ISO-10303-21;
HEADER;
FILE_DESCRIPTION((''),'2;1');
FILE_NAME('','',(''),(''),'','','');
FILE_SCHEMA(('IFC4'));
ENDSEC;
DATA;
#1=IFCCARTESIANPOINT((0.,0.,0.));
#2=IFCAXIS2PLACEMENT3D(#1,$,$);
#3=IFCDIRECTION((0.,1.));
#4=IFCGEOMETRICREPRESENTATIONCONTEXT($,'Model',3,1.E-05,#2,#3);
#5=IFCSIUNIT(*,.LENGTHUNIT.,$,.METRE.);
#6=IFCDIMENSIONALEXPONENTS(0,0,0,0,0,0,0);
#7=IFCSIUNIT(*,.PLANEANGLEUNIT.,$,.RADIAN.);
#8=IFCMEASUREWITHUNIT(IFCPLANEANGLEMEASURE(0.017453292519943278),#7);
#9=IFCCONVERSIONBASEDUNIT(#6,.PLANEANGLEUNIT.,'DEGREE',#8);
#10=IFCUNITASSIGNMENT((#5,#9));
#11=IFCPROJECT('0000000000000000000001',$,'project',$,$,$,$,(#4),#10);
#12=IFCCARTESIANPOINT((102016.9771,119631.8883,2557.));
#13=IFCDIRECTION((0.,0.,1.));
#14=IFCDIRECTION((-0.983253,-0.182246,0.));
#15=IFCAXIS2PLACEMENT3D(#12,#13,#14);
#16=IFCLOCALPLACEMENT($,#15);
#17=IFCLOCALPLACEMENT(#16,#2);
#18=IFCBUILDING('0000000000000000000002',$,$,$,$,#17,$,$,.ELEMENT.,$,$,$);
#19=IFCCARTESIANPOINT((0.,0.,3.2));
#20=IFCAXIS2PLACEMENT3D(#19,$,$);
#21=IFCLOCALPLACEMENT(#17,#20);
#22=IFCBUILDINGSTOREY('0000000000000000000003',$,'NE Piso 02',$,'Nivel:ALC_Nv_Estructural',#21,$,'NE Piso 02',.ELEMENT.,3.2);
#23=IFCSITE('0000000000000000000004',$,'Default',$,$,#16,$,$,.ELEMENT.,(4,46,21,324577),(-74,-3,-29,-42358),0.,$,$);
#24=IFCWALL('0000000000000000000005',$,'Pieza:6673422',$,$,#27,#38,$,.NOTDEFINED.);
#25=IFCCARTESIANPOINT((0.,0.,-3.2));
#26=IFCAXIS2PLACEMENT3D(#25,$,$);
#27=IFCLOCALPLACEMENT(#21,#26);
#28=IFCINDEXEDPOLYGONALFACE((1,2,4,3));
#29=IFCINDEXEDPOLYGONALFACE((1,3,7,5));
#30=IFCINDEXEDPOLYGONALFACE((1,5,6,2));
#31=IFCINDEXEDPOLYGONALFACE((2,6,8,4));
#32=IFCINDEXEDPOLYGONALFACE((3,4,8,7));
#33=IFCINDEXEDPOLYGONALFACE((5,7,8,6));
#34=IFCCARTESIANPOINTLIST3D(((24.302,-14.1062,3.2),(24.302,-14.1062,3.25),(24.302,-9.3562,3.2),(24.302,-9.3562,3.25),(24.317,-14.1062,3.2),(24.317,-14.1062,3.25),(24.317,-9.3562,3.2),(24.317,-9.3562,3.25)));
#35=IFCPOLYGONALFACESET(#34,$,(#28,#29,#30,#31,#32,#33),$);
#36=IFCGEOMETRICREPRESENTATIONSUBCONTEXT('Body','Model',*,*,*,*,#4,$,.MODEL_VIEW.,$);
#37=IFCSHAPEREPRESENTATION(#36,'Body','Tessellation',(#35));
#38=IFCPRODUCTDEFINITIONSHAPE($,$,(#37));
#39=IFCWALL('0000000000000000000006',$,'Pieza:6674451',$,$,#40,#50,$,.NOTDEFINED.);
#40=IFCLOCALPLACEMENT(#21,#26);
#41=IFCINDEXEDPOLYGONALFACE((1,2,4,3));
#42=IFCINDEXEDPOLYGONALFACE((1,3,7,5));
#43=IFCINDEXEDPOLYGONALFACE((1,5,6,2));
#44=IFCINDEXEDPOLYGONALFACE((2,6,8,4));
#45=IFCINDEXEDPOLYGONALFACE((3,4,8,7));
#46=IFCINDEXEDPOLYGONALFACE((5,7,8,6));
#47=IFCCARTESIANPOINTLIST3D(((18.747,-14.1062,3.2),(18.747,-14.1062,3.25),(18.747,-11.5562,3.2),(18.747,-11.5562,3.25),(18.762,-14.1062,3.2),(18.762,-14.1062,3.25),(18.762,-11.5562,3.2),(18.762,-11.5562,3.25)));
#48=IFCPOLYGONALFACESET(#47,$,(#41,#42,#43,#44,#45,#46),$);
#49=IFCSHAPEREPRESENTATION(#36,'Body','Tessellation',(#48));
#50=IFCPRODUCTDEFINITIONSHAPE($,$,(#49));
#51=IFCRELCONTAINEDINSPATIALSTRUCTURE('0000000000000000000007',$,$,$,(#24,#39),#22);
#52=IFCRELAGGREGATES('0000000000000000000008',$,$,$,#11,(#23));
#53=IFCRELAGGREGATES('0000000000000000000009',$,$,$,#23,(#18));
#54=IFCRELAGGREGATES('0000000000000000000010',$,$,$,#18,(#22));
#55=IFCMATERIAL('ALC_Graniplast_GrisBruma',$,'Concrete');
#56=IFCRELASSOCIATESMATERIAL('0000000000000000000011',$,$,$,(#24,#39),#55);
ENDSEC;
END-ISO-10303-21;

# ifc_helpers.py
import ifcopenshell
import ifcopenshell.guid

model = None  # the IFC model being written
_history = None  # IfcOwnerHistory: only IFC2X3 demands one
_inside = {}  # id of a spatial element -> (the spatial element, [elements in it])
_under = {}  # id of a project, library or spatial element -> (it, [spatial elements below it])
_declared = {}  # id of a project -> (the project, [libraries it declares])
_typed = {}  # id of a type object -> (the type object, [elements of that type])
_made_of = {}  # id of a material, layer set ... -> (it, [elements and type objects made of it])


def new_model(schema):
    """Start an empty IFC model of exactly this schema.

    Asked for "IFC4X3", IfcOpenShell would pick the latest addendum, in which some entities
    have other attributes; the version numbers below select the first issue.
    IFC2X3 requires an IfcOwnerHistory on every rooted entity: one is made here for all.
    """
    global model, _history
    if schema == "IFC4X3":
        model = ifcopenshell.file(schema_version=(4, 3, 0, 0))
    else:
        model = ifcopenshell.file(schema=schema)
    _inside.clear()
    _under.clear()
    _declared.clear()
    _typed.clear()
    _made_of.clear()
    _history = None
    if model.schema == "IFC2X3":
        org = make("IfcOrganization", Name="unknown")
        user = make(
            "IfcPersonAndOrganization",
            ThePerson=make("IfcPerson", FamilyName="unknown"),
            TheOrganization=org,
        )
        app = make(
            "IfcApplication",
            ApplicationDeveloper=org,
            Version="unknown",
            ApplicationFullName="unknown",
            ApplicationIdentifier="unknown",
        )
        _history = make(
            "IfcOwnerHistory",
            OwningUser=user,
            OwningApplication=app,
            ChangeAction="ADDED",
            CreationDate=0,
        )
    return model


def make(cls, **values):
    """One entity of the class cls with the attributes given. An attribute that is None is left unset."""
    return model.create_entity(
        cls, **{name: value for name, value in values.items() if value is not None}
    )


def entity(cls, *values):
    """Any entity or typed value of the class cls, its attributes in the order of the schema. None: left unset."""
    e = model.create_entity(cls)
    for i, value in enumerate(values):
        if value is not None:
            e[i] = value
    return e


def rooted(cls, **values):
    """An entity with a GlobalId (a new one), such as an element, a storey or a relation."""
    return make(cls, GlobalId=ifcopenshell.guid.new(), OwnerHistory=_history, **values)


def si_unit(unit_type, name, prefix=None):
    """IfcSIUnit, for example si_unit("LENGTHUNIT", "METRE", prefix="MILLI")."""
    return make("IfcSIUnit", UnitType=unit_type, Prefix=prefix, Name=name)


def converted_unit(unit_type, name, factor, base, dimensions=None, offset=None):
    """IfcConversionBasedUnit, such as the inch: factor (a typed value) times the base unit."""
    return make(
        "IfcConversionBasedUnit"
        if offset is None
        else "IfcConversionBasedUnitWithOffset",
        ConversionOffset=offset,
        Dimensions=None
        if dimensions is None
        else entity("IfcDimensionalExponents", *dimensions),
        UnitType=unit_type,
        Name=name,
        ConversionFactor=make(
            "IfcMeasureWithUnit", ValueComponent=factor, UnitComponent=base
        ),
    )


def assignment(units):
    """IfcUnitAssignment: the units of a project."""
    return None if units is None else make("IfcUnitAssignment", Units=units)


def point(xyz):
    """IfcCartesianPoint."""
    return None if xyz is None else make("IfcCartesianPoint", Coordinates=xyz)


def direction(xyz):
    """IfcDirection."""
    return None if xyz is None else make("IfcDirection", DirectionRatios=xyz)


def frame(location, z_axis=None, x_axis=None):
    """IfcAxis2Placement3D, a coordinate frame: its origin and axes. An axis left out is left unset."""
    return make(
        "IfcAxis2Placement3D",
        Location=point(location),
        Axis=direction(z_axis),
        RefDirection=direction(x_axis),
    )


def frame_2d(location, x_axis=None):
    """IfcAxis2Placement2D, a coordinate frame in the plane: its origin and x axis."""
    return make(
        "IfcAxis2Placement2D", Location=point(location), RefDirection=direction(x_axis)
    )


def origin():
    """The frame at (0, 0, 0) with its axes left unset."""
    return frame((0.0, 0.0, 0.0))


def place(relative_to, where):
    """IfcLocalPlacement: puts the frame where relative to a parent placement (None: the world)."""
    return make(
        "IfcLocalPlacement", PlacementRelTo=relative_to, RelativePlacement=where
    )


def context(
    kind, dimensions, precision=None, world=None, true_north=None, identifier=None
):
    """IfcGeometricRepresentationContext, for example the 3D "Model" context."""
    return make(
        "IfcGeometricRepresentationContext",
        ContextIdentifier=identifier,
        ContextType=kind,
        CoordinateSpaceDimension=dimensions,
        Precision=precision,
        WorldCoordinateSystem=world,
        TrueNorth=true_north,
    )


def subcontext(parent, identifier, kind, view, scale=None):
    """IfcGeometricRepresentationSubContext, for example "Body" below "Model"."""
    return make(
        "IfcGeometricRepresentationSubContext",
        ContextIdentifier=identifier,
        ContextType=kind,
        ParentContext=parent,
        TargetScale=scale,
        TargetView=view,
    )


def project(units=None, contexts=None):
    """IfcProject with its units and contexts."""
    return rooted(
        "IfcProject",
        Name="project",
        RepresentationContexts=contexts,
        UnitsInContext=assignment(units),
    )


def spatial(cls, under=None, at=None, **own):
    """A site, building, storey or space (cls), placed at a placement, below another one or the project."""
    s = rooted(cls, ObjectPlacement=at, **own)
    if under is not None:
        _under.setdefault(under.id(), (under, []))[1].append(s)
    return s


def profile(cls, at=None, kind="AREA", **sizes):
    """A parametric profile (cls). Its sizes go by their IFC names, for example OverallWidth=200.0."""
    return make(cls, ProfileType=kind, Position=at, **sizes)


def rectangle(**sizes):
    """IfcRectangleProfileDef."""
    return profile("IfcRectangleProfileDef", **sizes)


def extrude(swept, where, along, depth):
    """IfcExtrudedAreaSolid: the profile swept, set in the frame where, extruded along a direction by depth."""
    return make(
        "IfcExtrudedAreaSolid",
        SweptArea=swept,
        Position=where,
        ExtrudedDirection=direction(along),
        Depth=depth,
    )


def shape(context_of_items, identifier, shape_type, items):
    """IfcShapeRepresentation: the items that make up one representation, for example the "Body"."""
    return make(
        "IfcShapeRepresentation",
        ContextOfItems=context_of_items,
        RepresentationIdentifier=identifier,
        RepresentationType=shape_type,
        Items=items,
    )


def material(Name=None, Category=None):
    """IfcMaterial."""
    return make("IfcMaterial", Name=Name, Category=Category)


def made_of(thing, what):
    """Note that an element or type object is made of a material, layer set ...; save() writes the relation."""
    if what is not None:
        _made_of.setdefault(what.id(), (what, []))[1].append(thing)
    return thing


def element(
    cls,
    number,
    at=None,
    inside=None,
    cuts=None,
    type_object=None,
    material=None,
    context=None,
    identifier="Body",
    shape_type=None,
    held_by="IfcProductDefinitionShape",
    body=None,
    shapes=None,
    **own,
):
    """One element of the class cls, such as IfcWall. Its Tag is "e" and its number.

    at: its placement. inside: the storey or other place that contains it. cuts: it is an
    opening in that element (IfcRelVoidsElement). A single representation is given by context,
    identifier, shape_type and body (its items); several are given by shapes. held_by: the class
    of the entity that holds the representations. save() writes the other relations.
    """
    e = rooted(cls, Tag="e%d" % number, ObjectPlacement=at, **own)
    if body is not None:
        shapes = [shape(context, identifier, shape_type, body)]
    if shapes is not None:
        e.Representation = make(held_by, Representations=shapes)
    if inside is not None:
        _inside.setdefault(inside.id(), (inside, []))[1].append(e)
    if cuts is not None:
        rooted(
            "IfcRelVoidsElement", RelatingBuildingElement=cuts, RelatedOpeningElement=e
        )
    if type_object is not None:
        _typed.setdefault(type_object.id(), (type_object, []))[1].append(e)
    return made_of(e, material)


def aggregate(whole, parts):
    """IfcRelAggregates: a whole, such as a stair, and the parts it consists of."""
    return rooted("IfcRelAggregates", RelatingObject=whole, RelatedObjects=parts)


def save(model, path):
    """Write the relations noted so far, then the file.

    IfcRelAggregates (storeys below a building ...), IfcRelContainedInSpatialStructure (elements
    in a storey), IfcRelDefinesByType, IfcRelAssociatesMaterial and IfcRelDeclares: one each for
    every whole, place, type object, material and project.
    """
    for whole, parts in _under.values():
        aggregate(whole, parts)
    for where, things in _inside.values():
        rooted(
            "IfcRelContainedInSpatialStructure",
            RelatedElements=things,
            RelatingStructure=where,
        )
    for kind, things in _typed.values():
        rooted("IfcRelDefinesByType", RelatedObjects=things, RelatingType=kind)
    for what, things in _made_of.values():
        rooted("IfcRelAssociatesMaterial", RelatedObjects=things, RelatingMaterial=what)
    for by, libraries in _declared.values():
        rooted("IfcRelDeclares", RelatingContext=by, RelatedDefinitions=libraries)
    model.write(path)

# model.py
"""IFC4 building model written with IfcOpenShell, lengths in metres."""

from ifc_helpers import new_model, entity, si_unit, converted_unit, direction, frame, frame_2d, origin, place, context, subcontext, project, spatial, rectangle, extrude, material, element, save


model = new_model("IFC4")

# Units and contexts
model_context = context("Model", 3, precision=1e-05, world=origin(), true_north=direction((0.0, 1.0)))
body_context = subcontext(model_context, "Body", "Model", "MODEL_VIEW")
ifc_project = project(units=[si_unit("LENGTHUNIT", "METRE"), converted_unit("PLANEANGLEUNIT", "DEGREE", entity("IfcPlaneAngleMeasure", 0.017453292519943278), si_unit("PLANEANGLEUNIT", "RADIAN"), dimensions=[0, 0, 0, 0, 0, 0, 0])], contexts=[model_context])

# Site, building, storey
site_placement = place(None, frame((102016.9771, 119631.8883, 2557.0), z_axis=(0.0, 0.0, 1.0), x_axis=(-0.983253, -0.182246, 0.0)))
site = spatial("IfcSite", under=ifc_project, at=site_placement, Name="Default", CompositionType="ELEMENT", RefLatitude=(4, 46, 21, 324577), RefLongitude=(-74, -3, -29, -42358), RefElevation=0.0)
building_placement = place(site_placement, origin())
building = spatial("IfcBuilding", under=site, at=building_placement, CompositionType="ELEMENT")
storey_placement = place(building_placement, frame((0.0, 0.0, 3.2)))
storey = spatial("IfcBuildingStorey", under=building, at=storey_placement, Name="NE Piso 02", ObjectType="Nivel:ALC_Nv_Estructural", LongName="NE Piso 02", CompositionType="ELEMENT", Elevation=3.2)

# Walls
ifc_material_1 = material(Name="ALC_Graniplast_GrisBruma", Category="Concrete")
wall_1_placement = place(storey_placement, frame((0.0, 0.0, -3.2)))
element("IfcWall", 1, at=wall_1_placement, inside=storey, material=ifc_material_1, Name="Pieza:6673422", PredefinedType="NOTDEFINED", context=body_context, shape_type="SweptSolid", body=[
    extrude(rectangle(XDim=4.75, YDim=0.015, at=frame_2d((0.0, 0.0), x_axis=(1.0, 0.0))), frame((24.3095, -11.7312, 3.2), z_axis=(0.0, 0.0, 1.0), x_axis=(0.0, -1.0, 0.0)), (0.0, 0.0, 1.0), 0.05),
])
wall_2_placement = place(storey_placement, frame((0.0, 0.0, -3.2)))
element("IfcWall", 2, at=wall_2_placement, inside=storey, material=ifc_material_1, Name="Pieza:6674451", PredefinedType="NOTDEFINED", context=body_context, shape_type="SweptSolid", body=[
    extrude(rectangle(XDim=2.55, YDim=0.015, at=frame_2d((0.0, 0.0), x_axis=(1.0, 0.0))), frame((18.7545, -12.8312, 3.2), z_axis=(0.0, 0.0, 1.0), x_axis=(0.0, -1.0, 0.0)), (0.0, 0.0, 1.0), 0.05),
])

save(model, "model.ifc")
